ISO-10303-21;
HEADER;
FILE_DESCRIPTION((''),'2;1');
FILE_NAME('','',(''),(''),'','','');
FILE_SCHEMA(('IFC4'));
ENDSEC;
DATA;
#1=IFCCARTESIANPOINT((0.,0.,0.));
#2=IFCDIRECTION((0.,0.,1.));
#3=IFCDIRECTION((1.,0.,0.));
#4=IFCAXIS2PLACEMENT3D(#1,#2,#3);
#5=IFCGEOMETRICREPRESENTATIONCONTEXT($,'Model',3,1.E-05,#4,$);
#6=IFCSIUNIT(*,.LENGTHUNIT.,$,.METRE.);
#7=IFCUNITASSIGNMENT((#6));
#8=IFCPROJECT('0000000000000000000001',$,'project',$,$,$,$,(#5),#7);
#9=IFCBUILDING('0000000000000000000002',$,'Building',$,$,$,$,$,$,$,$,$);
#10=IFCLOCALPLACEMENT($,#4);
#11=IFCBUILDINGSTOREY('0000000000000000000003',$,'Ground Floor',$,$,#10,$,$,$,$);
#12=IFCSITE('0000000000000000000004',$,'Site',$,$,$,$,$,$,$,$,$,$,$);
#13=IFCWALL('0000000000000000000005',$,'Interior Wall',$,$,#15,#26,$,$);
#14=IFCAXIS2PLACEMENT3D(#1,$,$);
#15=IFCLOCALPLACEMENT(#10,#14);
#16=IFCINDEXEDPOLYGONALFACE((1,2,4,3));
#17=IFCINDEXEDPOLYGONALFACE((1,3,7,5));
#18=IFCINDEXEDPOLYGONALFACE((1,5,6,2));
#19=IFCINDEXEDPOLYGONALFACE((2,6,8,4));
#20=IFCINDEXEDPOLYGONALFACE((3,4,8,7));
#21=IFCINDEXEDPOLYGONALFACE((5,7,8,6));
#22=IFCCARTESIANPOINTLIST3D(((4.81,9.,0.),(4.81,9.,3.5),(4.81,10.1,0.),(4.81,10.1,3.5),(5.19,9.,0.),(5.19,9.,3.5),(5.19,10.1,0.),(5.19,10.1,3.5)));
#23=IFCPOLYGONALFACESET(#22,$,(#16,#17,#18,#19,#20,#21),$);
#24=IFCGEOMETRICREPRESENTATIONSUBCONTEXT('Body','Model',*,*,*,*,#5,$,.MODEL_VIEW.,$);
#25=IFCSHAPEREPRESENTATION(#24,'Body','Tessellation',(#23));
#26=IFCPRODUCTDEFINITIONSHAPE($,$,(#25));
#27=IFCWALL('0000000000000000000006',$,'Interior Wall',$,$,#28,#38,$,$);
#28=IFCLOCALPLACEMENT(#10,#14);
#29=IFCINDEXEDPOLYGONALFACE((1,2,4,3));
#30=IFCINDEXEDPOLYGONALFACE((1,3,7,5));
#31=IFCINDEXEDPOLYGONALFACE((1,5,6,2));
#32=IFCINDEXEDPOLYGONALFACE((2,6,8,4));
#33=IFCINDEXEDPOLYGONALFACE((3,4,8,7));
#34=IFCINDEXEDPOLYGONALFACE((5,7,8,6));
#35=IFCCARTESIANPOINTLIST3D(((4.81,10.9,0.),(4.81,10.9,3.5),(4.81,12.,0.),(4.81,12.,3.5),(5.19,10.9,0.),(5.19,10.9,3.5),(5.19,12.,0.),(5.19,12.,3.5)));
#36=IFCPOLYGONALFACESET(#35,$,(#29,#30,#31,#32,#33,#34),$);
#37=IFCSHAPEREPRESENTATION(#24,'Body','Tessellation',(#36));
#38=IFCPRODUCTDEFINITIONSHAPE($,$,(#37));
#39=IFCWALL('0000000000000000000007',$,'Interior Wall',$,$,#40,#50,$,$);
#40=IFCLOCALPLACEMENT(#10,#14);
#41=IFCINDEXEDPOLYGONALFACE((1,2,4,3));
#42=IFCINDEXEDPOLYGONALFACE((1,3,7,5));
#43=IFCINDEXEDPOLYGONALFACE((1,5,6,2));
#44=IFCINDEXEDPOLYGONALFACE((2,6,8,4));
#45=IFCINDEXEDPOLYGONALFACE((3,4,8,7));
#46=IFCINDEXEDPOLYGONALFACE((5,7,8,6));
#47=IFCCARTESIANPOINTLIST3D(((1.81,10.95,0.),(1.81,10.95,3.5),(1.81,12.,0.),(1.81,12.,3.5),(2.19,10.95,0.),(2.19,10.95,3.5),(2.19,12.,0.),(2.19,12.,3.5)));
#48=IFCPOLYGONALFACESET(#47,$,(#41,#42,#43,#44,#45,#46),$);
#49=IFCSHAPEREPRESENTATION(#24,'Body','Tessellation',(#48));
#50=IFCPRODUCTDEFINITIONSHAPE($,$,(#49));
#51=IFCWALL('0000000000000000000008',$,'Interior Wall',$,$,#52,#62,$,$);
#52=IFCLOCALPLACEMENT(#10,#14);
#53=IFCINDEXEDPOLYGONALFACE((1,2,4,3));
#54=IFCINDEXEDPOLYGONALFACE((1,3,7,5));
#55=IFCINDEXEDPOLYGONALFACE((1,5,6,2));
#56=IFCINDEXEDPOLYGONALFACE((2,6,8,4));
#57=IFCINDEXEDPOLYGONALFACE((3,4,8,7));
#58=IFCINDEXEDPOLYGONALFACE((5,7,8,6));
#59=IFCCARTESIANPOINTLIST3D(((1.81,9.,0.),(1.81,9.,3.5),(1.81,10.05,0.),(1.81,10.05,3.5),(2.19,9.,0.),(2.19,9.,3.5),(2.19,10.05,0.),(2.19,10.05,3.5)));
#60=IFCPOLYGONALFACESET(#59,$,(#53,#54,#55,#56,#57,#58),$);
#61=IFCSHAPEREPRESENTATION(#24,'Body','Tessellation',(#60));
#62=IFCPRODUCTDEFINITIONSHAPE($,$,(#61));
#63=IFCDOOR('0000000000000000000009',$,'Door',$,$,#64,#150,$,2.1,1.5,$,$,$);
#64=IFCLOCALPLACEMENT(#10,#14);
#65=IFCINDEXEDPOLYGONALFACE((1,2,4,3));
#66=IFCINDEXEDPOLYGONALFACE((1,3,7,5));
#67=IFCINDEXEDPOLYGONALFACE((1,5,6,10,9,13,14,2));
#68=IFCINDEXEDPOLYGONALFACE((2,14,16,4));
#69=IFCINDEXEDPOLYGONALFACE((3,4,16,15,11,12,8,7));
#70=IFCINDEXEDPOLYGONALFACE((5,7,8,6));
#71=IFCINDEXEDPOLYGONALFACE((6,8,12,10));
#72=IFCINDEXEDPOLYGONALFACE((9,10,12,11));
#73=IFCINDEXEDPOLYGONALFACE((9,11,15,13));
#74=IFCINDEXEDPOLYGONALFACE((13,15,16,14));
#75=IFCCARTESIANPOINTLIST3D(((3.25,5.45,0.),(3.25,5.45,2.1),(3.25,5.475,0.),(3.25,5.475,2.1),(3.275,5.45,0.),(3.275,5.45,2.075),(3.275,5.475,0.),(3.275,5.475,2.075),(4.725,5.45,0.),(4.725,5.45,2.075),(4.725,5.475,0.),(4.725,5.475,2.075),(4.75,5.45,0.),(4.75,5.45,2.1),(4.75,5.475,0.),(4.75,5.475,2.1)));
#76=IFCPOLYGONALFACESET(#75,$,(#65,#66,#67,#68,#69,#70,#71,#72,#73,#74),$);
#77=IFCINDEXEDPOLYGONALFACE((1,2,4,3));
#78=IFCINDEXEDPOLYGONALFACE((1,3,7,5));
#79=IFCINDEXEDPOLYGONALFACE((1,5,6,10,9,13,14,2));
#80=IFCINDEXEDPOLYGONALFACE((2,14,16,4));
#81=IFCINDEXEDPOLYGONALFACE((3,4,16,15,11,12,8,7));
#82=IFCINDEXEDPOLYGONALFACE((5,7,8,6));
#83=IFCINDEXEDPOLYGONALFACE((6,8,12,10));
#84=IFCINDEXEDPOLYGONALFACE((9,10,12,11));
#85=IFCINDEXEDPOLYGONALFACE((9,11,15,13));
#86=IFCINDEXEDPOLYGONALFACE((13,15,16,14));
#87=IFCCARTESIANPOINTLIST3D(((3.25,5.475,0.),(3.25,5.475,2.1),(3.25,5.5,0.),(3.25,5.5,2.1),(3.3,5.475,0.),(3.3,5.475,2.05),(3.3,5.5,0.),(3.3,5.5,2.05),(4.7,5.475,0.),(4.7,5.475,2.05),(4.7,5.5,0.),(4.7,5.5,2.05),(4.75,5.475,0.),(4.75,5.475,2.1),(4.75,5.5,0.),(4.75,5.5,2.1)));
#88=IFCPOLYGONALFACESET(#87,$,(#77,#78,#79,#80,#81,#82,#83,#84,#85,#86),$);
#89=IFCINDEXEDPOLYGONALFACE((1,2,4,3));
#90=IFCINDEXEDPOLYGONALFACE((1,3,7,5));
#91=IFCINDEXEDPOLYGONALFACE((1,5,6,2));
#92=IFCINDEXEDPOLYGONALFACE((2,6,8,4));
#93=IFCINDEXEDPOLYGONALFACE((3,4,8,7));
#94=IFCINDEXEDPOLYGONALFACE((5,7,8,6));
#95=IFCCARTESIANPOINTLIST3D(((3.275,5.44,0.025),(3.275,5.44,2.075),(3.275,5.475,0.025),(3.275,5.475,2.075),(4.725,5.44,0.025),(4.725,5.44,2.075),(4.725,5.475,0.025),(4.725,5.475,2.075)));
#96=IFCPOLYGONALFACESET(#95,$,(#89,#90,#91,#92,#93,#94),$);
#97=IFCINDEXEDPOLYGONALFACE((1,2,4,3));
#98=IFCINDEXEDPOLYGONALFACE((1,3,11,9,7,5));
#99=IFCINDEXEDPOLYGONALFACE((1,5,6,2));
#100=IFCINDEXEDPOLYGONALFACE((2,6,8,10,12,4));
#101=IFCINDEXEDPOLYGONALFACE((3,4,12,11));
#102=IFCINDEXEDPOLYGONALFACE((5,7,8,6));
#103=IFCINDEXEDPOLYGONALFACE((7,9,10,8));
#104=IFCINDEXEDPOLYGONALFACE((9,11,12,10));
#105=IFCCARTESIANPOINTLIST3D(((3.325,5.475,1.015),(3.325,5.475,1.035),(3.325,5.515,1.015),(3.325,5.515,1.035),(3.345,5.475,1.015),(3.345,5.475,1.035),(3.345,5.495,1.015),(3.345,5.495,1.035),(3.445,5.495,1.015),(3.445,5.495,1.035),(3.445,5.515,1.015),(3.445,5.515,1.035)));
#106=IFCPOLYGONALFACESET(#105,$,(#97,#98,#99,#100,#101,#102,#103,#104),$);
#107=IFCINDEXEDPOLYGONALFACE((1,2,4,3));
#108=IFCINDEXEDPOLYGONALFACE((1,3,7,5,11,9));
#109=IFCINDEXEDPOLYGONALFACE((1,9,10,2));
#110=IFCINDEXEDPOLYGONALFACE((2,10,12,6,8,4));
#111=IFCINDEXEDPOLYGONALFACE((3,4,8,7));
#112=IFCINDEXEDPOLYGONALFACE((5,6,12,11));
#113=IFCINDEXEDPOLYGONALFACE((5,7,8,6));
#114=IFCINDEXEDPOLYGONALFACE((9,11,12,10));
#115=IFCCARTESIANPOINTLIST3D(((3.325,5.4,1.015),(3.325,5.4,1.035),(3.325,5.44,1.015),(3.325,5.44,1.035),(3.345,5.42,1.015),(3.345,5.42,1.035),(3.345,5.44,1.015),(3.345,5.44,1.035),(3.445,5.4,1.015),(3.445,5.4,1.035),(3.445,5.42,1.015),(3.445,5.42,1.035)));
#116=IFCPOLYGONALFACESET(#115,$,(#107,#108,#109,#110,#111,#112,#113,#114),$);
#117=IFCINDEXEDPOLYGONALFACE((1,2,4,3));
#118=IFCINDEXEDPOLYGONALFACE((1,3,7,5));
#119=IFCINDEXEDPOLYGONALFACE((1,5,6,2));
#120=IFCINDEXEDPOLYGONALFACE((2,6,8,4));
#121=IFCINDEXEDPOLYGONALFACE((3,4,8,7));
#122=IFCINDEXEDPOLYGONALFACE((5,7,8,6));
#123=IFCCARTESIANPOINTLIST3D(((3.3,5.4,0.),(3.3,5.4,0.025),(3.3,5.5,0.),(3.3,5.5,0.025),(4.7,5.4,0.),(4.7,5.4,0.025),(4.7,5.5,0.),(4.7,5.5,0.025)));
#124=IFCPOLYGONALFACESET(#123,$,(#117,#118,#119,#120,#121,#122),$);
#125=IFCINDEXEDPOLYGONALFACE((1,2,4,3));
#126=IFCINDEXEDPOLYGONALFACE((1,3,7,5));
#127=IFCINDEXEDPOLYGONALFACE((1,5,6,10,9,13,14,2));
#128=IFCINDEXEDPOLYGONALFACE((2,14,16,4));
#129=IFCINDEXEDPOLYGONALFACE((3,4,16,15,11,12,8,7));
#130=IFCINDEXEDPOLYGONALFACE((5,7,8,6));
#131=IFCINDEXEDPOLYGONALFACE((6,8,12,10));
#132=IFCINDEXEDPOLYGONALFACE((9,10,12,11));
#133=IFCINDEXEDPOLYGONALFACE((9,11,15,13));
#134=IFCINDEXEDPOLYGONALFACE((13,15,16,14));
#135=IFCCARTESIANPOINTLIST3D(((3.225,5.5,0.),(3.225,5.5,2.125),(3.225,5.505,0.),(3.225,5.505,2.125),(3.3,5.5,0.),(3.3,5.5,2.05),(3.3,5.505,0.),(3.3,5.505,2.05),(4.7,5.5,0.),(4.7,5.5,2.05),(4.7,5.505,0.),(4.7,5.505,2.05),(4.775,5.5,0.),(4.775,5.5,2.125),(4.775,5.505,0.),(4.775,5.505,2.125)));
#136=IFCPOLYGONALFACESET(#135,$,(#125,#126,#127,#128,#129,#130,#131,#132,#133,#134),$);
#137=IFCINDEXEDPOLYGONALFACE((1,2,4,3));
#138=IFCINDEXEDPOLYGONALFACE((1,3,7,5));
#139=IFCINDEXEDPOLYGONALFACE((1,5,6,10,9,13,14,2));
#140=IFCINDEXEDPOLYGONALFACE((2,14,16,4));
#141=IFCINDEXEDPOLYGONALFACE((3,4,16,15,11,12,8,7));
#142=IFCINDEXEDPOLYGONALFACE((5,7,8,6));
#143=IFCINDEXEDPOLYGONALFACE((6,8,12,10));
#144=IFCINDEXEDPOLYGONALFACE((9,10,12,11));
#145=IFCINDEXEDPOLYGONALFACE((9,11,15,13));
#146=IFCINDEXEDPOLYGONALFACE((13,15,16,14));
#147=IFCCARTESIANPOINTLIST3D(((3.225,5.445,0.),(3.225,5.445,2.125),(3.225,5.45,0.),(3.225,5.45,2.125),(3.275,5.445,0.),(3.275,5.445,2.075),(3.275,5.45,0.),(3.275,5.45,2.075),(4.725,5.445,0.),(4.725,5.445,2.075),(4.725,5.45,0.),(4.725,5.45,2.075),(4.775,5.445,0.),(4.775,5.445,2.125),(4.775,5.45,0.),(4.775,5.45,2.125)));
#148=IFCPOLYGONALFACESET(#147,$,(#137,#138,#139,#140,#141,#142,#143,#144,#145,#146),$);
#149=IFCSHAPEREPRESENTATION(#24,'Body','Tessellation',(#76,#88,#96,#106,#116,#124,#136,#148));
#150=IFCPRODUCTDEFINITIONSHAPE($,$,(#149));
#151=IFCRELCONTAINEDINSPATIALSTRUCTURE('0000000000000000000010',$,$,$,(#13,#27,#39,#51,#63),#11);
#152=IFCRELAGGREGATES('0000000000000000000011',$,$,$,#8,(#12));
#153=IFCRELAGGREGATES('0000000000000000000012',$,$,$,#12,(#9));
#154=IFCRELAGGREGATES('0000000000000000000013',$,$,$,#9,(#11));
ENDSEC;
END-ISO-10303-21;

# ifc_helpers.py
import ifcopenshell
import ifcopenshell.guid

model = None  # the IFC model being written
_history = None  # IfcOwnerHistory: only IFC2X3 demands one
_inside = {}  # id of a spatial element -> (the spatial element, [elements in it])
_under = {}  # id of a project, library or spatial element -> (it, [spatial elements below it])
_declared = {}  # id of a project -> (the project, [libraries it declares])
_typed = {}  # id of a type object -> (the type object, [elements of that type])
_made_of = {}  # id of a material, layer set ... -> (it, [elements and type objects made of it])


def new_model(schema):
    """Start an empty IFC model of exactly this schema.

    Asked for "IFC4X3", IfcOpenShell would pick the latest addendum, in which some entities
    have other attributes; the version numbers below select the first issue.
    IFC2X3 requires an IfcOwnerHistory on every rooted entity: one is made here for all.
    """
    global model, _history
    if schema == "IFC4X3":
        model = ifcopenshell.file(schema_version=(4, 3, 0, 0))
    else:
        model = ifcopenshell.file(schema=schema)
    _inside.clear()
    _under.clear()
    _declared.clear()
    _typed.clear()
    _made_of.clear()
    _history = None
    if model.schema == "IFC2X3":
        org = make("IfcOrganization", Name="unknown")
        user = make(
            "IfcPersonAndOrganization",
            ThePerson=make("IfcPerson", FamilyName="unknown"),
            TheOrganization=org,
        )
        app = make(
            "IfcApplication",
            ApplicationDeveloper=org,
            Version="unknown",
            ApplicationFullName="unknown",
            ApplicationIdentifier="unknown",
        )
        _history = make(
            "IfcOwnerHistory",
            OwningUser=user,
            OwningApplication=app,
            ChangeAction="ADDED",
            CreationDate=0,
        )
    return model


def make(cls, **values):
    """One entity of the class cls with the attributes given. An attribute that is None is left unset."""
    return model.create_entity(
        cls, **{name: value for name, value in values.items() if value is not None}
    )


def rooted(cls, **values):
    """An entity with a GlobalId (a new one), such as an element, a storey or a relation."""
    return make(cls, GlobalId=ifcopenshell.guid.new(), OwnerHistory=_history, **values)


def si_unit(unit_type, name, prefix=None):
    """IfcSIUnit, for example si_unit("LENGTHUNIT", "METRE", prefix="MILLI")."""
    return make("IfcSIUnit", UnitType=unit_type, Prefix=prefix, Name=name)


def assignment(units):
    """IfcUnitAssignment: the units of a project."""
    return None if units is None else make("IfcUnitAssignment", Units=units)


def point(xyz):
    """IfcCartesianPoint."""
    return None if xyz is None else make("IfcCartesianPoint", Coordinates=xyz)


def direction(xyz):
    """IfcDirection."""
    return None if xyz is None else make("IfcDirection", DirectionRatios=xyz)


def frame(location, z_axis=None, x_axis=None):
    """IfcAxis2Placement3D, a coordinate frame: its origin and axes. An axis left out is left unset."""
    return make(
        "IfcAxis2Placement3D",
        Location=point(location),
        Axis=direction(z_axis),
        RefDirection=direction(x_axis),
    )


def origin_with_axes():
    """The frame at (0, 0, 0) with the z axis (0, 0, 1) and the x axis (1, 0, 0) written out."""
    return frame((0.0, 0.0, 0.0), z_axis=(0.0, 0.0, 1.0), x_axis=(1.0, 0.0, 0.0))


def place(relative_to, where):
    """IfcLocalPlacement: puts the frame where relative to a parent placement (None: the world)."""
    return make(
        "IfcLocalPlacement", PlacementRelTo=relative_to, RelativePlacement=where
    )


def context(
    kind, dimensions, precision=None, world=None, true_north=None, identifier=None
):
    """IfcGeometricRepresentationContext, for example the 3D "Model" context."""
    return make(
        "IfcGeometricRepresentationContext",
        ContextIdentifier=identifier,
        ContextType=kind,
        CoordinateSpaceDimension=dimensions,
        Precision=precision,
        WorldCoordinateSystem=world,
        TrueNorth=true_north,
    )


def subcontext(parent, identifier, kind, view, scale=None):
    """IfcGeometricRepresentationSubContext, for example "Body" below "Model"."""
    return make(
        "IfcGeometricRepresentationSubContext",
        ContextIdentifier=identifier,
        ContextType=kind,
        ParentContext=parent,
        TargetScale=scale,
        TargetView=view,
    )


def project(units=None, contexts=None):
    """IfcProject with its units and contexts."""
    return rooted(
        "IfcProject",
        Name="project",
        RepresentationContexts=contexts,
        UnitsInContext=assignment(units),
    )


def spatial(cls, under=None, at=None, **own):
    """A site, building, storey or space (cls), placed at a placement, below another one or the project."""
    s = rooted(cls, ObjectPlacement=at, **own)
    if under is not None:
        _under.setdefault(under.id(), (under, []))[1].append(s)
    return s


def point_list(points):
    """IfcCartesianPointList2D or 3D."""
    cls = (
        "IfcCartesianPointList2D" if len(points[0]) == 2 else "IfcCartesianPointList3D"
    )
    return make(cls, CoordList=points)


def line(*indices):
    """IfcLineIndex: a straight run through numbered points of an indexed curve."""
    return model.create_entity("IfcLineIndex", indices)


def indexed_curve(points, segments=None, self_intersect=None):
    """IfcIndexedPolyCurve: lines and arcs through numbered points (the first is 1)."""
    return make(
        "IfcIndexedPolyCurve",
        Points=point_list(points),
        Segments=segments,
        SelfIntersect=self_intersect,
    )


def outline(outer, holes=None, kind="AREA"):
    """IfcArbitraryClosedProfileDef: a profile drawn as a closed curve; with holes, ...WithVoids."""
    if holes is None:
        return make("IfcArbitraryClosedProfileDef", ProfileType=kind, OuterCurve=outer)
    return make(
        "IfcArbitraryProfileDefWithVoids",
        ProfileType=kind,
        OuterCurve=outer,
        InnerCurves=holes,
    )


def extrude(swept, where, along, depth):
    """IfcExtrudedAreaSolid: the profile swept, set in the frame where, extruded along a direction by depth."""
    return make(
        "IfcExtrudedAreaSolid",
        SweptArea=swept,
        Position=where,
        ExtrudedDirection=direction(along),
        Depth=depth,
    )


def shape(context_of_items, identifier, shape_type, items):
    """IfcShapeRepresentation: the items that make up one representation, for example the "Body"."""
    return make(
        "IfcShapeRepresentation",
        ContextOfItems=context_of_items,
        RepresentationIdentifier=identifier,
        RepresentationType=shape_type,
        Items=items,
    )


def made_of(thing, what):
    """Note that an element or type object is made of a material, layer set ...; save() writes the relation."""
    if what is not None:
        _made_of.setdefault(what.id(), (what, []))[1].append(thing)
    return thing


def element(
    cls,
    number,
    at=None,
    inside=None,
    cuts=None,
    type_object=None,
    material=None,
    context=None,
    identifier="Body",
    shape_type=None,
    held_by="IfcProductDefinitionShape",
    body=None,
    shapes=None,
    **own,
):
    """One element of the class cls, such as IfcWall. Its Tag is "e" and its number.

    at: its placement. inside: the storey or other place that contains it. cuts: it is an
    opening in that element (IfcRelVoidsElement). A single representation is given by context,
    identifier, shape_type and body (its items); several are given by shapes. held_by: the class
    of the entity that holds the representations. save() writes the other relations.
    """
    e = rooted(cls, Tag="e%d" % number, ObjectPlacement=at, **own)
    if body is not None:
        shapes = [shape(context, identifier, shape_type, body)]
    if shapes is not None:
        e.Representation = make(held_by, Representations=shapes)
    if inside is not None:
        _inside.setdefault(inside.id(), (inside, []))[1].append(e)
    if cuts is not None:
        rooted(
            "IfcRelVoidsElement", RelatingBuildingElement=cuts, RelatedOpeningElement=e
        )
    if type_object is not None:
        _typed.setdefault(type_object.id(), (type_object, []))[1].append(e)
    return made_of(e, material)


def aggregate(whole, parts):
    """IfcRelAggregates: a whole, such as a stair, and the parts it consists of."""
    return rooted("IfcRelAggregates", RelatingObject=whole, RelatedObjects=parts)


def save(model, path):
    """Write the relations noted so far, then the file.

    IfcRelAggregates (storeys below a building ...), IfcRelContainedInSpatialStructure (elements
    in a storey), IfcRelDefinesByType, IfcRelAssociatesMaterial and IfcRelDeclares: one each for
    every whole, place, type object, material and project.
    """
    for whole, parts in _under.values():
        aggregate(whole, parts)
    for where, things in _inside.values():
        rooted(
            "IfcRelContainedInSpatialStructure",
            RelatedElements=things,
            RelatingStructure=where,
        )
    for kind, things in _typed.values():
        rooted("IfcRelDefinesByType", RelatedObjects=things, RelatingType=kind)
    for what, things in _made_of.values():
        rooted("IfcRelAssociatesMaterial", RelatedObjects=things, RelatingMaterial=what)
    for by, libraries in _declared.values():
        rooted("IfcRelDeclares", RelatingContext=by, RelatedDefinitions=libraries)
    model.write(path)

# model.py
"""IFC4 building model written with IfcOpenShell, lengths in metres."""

from ifc_helpers import new_model, si_unit, frame, origin_with_axes, place, context, subcontext, project, spatial, line, indexed_curve, outline, extrude, element, save


model = new_model("IFC4")

# Units and contexts
model_context = context("Model", 3, precision=1e-05, world=origin_with_axes())
body_context = subcontext(model_context, "Body", "Model", "MODEL_VIEW")
ifc_project = project(units=[si_unit("LENGTHUNIT", "METRE")], contexts=[model_context])

# Site, building, storey
site = spatial("IfcSite", under=ifc_project, Name="Site")
building = spatial("IfcBuilding", under=site, Name="Building")
storey_placement = place(None, origin_with_axes())
storey = spatial("IfcBuildingStorey", under=building, at=storey_placement, Name="Ground Floor")

# Walls
for number, where, z_axis, x_axis, name in (
    (1, (5.0, 9.0, 0.0), (0.0, 0.0, 1.0), (0.0, 1.0, 0.0), "Interior Wall"),
    (2, (5.0, 10.9, 0.0), (0.0, 0.0, 1.0), (0.0, 1.0, 0.0), "Interior Wall"),
):
    element("IfcWall", number, at=place(storey_placement, frame(where, z_axis=z_axis, x_axis=x_axis)), inside=storey, Name=name, context=body_context, shape_type="SweptSolid", body=[
        extrude(outline(indexed_curve([(0.0, 0.0), (0.0, 0.38), (1.1, 0.38), (1.1, 0.0), (0.0, 0.0)], self_intersect=False)), frame((0.0, -0.19, 0.0), z_axis=(0.0, 0.0, 1.0), x_axis=(1.0, 0.0, 0.0)), (0.0, 0.0, 1.0), 3.5),
    ])
for number, where, z_axis, x_axis, name in (
    (3, (2.0, 12.0, 0.0), (0.0, 0.0, 1.0), (0.0, -1.0, 0.0), "Interior Wall"),
    (4, (2.0, 10.05, 0.0), (0.0, 0.0, 1.0), (0.0, -1.0, 0.0), "Interior Wall"),
):
    element("IfcWall", number, at=place(storey_placement, frame(where, z_axis=z_axis, x_axis=x_axis)), inside=storey, Name=name, context=body_context, shape_type="SweptSolid", body=[
        extrude(outline(indexed_curve([(0.0, 0.0), (0.0, 0.38), (1.05, 0.38), (1.05, 0.0), (0.0, 0.0)], self_intersect=False)), frame((0.0, -0.19, 0.0), z_axis=(0.0, 0.0, 1.0), x_axis=(1.0, 0.0, 0.0)), (0.0, 0.0, 1.0), 3.5),
    ])

# Door
door_1_placement = place(storey_placement, frame((4.75, 5.5, 0.0), z_axis=(0.0, 0.0, 1.0), x_axis=(-1.0, 0.0, 0.0)))
element("IfcDoor", 5, at=door_1_placement, inside=storey, Name="Door", OverallHeight=2.1, OverallWidth=1.5, context=body_context, shape_type="SweptSolid", body=[
    extrude(outline(indexed_curve([(0.0, 0.0), (0.0, 2.1), (1.5, 2.1), (1.5, 0.0), (1.475, 0.0), (1.475, 2.075), (0.025, 2.075), (0.025, 0.0)], segments=[line(1, 2, 3, 4, 5, 6, 7, 8, 1)])), frame((0.0, 0.025, 0.0), z_axis=(0.0, -1.0, 0.0), x_axis=(1.0, 0.0, 0.0)), (0.0, 0.0, -1.0), 0.025),
    extrude(outline(indexed_curve([(0.0, 0.0), (0.0, 2.1), (1.5, 2.1), (1.5, 0.0), (1.45, 0.0), (1.45, 2.05), (0.05, 2.05), (0.05, 0.0)], segments=[line(1, 2, 3, 4, 5, 6, 7, 8, 1)])), frame((0.0, 0.0, 0.0), z_axis=(0.0, -1.0, 0.0), x_axis=(1.0, 0.0, 0.0)), (0.0, 0.0, -1.0), 0.025),
    extrude(outline(indexed_curve([(0.0, 0.0), (1.45, 0.0), (1.45, 0.035), (0.0, 0.035)], segments=[line(1, 2, 3, 4, 1)])), frame((0.025, 0.025, 0.025), z_axis=(0.0, 0.0, 1.0), x_axis=(1.0, 0.0, 0.0)), (0.0, 0.0, 1.0), 2.05),
    extrude(outline(indexed_curve([(0.0, 0.0), (0.0, -0.04), (-0.12, -0.04), (-0.12, -0.02), (-0.02, -0.02), (-0.02, 0.0)], segments=[line(1, 2, 3, 4, 5, 6, 1)])), frame((1.425, 0.025, 1.015), z_axis=(0.0, 0.0, 1.0), x_axis=(1.0, 0.0, 0.0)), (0.0, 0.0, 1.0), 0.02),
    extrude(outline(indexed_curve([(0.0, 0.0), (0.0, 0.04), (-0.12, 0.04), (-0.12, 0.02), (-0.02, 0.02), (-0.02, 0.0)], segments=[line(1, 2, 3, 4, 5, 6, 1)])), frame((1.425, 0.06, 1.015), z_axis=(0.0, 0.0, 1.0), x_axis=(1.0, 0.0, 0.0)), (0.0, 0.0, 1.0), 0.02),
    extrude(outline(indexed_curve([(0.0, 0.0), (1.4, 0.0), (1.4, 0.1), (0.0, 0.1)], segments=[line(1, 2, 3, 4, 1)])), frame((0.05, 0.0, 0.0), z_axis=(0.0, 0.0, 1.0), x_axis=(1.0, 0.0, 0.0)), (0.0, 0.0, 1.0), 0.025),
    extrude(outline(indexed_curve([(0.0, 0.0), (0.0, 2.125), (1.55, 2.125), (1.55, 0.0), (1.475, 0.0), (1.475, 2.05), (0.075, 2.05), (0.075, 0.0)], segments=[line(1, 2, 3, 4, 5, 6, 7, 8, 1)])), frame((-0.025, -0.005, 0.0), z_axis=(0.0, -1.0, 0.0), x_axis=(1.0, 0.0, 0.0)), (0.0, 0.0, -1.0), 0.005),
    extrude(outline(indexed_curve([(0.0, 0.0), (0.0, 2.125), (1.55, 2.125), (1.55, 0.0), (1.5, 0.0), (1.5, 2.075), (0.05, 2.075), (0.05, 0.0)], segments=[line(1, 2, 3, 4, 5, 6, 7, 8, 1)])), frame((-0.025, 0.05, 0.0), z_axis=(0.0, -1.0, 0.0), x_axis=(1.0, 0.0, 0.0)), (0.0, 0.0, -1.0), 0.005),
])

save(model, "model.ifc")
